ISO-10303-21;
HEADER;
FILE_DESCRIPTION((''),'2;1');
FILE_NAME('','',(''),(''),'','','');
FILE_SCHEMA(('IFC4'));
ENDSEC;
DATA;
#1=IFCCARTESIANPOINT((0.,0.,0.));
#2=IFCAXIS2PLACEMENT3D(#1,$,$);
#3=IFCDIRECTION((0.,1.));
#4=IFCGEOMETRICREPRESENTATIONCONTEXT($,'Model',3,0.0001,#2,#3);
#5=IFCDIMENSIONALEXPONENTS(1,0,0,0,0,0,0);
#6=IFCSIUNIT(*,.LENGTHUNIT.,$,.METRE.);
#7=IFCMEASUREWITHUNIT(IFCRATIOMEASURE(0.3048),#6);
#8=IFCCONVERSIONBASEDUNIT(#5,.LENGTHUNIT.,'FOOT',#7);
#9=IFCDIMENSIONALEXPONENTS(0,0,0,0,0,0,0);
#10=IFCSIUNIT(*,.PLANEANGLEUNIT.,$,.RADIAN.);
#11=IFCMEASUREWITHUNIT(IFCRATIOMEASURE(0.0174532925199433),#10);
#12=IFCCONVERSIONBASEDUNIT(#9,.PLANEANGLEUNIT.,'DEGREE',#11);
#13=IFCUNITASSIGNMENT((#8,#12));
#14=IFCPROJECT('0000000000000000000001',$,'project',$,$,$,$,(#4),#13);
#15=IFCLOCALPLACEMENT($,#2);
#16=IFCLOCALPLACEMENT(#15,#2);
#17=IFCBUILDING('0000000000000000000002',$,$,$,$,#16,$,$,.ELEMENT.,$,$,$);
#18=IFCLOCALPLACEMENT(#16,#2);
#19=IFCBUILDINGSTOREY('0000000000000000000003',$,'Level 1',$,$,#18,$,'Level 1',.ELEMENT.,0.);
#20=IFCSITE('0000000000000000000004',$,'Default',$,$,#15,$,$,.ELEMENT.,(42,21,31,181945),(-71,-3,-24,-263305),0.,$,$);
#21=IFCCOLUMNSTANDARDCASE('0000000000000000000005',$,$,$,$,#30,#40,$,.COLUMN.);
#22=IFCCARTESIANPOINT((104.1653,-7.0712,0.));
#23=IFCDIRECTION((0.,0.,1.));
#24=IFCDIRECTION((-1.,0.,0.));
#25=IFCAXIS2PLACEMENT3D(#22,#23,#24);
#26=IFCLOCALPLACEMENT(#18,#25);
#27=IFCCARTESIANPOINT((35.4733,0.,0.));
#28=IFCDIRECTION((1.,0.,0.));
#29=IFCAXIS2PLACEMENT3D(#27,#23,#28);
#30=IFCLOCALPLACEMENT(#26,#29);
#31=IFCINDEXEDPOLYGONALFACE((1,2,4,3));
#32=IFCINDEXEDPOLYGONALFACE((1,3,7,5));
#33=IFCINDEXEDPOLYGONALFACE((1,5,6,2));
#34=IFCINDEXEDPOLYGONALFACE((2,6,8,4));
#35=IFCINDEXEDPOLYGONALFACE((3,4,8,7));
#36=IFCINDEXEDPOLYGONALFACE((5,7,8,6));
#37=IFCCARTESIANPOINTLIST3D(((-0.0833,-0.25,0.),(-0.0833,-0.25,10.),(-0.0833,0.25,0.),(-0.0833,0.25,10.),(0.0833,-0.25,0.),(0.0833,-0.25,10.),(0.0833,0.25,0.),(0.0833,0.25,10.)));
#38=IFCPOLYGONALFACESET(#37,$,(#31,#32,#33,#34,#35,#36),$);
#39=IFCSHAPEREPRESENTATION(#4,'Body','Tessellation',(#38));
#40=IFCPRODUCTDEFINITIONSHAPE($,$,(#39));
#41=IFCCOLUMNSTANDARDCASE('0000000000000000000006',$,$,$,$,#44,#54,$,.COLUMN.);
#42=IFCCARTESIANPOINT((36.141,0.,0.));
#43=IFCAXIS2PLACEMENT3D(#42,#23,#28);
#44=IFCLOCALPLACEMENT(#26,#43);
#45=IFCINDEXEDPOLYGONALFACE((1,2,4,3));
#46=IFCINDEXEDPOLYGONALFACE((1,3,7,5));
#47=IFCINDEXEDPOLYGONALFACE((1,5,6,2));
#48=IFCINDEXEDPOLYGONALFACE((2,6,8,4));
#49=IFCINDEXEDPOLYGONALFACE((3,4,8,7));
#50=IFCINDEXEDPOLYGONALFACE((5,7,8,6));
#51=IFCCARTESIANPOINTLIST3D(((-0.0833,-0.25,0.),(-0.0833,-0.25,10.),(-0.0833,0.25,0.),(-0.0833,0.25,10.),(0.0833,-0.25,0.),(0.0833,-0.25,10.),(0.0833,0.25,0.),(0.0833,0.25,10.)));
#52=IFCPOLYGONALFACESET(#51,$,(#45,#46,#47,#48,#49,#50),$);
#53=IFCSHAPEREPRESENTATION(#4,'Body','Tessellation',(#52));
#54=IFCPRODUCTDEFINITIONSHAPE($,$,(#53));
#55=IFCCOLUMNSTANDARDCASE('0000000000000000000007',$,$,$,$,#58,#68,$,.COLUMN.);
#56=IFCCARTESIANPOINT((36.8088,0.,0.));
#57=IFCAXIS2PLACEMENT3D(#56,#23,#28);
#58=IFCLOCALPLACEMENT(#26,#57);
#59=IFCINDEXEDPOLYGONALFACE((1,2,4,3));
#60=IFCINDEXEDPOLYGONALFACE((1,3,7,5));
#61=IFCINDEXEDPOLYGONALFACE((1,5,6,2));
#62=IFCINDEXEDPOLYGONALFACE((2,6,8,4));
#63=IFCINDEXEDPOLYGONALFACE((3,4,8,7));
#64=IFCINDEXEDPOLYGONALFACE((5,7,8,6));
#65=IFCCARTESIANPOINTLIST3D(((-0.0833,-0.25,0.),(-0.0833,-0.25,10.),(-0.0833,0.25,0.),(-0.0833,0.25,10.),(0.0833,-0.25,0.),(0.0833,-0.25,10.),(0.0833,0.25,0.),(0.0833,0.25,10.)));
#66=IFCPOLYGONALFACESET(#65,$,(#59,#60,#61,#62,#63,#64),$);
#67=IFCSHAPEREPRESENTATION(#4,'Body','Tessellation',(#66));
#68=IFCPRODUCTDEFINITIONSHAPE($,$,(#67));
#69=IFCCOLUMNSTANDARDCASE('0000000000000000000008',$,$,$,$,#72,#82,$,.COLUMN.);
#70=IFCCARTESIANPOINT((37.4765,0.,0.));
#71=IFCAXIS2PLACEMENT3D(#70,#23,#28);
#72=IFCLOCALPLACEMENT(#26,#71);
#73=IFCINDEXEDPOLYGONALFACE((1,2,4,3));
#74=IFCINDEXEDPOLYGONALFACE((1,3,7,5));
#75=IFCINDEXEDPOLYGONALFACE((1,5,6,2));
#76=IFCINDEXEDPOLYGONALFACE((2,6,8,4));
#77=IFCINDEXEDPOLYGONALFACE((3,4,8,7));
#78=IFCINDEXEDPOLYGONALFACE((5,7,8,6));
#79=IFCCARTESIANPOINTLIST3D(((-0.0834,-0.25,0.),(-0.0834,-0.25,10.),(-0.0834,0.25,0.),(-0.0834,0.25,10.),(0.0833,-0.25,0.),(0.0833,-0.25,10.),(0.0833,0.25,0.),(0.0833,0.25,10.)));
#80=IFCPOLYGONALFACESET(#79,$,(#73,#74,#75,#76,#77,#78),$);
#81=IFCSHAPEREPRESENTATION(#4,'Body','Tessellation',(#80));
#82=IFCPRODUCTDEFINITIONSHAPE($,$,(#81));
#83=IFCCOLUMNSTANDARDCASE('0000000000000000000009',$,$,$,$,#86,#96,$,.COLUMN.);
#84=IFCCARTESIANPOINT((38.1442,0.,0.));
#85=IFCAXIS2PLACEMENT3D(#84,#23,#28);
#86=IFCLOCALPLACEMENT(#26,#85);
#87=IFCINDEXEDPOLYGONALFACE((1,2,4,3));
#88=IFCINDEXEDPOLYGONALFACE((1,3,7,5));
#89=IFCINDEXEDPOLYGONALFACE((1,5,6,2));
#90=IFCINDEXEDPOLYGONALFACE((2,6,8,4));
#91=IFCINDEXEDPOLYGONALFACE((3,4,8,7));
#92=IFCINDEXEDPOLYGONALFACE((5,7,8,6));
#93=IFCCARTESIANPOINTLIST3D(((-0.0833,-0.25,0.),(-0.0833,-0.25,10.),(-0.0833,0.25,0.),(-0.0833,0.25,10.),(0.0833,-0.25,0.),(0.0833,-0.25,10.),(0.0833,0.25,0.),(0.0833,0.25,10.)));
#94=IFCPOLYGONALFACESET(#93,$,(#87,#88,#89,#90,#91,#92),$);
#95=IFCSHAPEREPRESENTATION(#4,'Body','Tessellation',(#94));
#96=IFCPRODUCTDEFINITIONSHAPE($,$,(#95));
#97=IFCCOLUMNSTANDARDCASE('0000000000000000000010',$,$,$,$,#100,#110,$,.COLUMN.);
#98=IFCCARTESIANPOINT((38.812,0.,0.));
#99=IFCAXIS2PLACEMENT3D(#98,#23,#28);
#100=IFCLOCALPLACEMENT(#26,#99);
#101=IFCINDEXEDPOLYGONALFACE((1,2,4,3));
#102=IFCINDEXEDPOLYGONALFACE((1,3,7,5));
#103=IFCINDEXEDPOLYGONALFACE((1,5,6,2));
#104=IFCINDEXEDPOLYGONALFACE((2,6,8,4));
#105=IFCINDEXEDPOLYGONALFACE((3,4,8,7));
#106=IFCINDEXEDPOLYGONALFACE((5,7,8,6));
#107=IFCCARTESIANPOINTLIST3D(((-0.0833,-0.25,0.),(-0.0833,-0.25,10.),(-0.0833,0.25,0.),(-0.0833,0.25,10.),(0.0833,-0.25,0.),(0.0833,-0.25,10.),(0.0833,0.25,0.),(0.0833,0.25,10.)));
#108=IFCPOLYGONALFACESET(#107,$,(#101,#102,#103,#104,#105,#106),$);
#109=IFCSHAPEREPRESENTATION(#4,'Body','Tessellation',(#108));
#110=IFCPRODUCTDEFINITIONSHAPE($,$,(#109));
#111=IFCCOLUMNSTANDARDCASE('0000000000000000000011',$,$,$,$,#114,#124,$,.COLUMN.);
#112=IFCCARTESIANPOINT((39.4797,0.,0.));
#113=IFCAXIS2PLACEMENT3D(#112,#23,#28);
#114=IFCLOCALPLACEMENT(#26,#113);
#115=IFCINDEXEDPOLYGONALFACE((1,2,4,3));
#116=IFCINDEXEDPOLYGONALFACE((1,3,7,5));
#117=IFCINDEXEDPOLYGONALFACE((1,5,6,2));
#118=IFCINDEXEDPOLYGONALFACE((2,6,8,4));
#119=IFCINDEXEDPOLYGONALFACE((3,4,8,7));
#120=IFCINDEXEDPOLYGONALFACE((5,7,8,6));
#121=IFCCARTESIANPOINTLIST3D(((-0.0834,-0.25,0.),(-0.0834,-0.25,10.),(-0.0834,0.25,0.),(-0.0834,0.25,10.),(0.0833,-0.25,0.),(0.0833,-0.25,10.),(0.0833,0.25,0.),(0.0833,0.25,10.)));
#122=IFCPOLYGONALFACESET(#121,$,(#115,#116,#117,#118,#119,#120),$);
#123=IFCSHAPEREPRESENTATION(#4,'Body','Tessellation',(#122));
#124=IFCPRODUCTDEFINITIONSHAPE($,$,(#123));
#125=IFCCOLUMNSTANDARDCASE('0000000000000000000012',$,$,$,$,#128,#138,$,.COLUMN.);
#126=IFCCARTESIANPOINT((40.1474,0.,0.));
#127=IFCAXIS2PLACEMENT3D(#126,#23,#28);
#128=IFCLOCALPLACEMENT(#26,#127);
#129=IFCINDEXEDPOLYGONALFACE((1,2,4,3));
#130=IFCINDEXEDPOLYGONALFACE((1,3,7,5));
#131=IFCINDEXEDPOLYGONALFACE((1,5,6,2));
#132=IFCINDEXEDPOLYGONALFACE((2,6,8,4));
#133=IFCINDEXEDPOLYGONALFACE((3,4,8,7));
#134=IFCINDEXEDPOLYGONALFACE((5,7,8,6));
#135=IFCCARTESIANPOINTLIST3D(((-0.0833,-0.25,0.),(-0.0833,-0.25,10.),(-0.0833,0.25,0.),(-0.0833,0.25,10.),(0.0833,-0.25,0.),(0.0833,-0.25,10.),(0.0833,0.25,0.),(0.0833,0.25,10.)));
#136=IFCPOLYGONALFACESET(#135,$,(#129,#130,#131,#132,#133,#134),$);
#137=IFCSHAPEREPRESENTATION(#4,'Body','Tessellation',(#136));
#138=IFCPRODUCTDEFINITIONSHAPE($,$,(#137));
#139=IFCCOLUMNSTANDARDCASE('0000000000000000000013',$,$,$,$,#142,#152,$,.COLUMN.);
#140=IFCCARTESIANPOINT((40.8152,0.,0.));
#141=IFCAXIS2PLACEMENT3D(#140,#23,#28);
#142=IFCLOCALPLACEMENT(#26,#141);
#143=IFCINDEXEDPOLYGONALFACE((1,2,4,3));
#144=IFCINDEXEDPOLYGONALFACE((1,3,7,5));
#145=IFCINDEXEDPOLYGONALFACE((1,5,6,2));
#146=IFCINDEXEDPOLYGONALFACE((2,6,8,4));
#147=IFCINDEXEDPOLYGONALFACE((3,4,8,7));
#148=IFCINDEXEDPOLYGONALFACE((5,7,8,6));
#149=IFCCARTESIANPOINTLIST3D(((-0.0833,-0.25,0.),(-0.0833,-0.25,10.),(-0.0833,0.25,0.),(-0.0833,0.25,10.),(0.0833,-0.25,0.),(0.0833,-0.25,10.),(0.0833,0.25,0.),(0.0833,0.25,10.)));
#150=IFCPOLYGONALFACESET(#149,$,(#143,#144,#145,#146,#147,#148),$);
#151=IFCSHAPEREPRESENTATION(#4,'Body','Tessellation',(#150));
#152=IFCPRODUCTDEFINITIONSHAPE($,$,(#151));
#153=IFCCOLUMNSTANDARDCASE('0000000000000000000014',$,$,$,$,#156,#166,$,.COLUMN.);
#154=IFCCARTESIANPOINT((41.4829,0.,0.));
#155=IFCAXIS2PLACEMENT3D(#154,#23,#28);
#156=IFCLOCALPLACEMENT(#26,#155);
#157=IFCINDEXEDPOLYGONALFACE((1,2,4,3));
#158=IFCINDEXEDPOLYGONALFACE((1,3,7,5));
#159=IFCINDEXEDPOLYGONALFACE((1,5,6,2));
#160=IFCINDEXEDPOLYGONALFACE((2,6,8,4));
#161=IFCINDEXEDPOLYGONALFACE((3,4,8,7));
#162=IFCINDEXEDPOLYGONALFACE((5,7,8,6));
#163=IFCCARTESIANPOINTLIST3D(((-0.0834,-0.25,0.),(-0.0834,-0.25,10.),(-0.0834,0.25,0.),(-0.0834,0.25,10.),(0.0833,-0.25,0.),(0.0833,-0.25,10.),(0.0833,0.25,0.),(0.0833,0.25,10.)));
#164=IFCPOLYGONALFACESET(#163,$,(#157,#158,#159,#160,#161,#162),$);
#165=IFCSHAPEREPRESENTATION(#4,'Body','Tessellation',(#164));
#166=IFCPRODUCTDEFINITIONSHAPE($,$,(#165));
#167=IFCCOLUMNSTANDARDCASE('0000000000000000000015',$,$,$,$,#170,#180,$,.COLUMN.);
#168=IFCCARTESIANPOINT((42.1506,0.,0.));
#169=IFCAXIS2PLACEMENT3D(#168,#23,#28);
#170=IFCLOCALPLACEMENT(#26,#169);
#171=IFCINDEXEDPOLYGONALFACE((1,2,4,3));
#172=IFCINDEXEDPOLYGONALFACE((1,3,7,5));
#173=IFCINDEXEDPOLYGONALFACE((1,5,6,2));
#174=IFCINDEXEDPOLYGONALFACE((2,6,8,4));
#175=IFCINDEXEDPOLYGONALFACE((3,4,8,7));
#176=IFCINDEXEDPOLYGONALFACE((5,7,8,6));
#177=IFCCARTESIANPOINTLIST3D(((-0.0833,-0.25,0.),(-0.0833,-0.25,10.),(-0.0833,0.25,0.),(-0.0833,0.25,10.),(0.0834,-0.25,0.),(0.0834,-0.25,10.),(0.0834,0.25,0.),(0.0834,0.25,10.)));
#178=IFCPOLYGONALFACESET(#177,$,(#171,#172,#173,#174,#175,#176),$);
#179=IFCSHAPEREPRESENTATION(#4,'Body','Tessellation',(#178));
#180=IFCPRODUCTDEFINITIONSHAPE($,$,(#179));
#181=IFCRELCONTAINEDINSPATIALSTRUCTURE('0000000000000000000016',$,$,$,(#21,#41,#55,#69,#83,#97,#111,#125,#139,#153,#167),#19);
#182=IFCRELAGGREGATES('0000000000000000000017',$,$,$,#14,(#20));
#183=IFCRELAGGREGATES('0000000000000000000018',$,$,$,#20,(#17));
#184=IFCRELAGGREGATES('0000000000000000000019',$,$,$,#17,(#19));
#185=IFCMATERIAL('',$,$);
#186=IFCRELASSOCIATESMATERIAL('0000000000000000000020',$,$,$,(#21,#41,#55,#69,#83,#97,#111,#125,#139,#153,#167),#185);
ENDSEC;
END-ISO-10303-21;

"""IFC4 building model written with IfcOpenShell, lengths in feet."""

from ifc_helpers import new_model, entity, si_unit, converted_unit, direction, frame, origin, place, context, project, spatial, rectangle, extrude, material, element, save


model = new_model("IFC4")

# Units and contexts
model_context = context("Model", 3, precision=0.0001, world=origin(), true_north=direction((0.0, 1.0)))
ifc_project = project(units=[converted_unit("LENGTHUNIT", "FOOT", entity("IfcRatioMeasure", 0.3048), si_unit("LENGTHUNIT", "METRE"), dimensions=[1, 0, 0, 0, 0, 0, 0]), converted_unit("PLANEANGLEUNIT", "DEGREE", entity("IfcRatioMeasure", 0.0174532925199433), si_unit("PLANEANGLEUNIT", "RADIAN"), dimensions=[0, 0, 0, 0, 0, 0, 0])], contexts=[model_context])

# Site, building, storey
site_placement = place(None, origin())
site = spatial("IfcSite", under=ifc_project, at=site_placement, Name="Default", CompositionType="ELEMENT", RefLatitude=(42, 21, 31, 181945), RefLongitude=(-71, -3, -24, -263305), RefElevation=0.0)
building_placement = place(site_placement, origin())
building = spatial("IfcBuilding", under=site, at=building_placement, CompositionType="ELEMENT")
storey_placement = place(building_placement, origin())
storey = spatial("IfcBuildingStorey", under=building, at=storey_placement, Name="Level 1", LongName="Level 1", CompositionType="ELEMENT", Elevation=0.0)

# Columns
ifc_material = material(Name="")
placement = place(storey_placement, frame((104.1653, -7.0712, 0.0), z_axis=(0.0, 0.0, 1.0), x_axis=(-1.0, 0.0, 0.0)))
for number, where, z_axis, x_axis in (
    (1, (35.4733, 0.0, 0.0), (0.0, 0.0, 1.0), (1.0, 0.0, 0.0)),
    (2, (36.141, 0.0, 0.0), (0.0, 0.0, 1.0), (1.0, 0.0, 0.0)),
    (3, (36.8088, 0.0, 0.0), (0.0, 0.0, 1.0), (1.0, 0.0, 0.0)),
    (4, (37.4765, 0.0, 0.0), (0.0, 0.0, 1.0), (1.0, 0.0, 0.0)),
    (5, (38.1442, 0.0, 0.0), (0.0, 0.0, 1.0), (1.0, 0.0, 0.0)),
    (6, (38.812, 0.0, 0.0), (0.0, 0.0, 1.0), (1.0, 0.0, 0.0)),
    (7, (39.4797, 0.0, 0.0), (0.0, 0.0, 1.0), (1.0, 0.0, 0.0)),
    (8, (40.1474, 0.0, 0.0), (0.0, 0.0, 1.0), (1.0, 0.0, 0.0)),
    (9, (40.8152, 0.0, 0.0), (0.0, 0.0, 1.0), (1.0, 0.0, 0.0)),
    (10, (41.4829, 0.0, 0.0), (0.0, 0.0, 1.0), (1.0, 0.0, 0.0)),
    (11, (42.1506, 0.0, 0.0), (0.0, 0.0, 1.0), (1.0, 0.0, 0.0)),
):
    element("IfcColumnStandardCase", number, at=place(placement, frame(where, z_axis=z_axis, x_axis=x_axis)), inside=storey, material=ifc_material, PredefinedType="COLUMN", context=model_context, shape_type="SweptSolid", body=[
        extrude(rectangle(XDim=0.1667, YDim=0.5), origin(), (0.0, 0.0, 1.0), 10.0),
    ])

save(model, "model.ifc")
